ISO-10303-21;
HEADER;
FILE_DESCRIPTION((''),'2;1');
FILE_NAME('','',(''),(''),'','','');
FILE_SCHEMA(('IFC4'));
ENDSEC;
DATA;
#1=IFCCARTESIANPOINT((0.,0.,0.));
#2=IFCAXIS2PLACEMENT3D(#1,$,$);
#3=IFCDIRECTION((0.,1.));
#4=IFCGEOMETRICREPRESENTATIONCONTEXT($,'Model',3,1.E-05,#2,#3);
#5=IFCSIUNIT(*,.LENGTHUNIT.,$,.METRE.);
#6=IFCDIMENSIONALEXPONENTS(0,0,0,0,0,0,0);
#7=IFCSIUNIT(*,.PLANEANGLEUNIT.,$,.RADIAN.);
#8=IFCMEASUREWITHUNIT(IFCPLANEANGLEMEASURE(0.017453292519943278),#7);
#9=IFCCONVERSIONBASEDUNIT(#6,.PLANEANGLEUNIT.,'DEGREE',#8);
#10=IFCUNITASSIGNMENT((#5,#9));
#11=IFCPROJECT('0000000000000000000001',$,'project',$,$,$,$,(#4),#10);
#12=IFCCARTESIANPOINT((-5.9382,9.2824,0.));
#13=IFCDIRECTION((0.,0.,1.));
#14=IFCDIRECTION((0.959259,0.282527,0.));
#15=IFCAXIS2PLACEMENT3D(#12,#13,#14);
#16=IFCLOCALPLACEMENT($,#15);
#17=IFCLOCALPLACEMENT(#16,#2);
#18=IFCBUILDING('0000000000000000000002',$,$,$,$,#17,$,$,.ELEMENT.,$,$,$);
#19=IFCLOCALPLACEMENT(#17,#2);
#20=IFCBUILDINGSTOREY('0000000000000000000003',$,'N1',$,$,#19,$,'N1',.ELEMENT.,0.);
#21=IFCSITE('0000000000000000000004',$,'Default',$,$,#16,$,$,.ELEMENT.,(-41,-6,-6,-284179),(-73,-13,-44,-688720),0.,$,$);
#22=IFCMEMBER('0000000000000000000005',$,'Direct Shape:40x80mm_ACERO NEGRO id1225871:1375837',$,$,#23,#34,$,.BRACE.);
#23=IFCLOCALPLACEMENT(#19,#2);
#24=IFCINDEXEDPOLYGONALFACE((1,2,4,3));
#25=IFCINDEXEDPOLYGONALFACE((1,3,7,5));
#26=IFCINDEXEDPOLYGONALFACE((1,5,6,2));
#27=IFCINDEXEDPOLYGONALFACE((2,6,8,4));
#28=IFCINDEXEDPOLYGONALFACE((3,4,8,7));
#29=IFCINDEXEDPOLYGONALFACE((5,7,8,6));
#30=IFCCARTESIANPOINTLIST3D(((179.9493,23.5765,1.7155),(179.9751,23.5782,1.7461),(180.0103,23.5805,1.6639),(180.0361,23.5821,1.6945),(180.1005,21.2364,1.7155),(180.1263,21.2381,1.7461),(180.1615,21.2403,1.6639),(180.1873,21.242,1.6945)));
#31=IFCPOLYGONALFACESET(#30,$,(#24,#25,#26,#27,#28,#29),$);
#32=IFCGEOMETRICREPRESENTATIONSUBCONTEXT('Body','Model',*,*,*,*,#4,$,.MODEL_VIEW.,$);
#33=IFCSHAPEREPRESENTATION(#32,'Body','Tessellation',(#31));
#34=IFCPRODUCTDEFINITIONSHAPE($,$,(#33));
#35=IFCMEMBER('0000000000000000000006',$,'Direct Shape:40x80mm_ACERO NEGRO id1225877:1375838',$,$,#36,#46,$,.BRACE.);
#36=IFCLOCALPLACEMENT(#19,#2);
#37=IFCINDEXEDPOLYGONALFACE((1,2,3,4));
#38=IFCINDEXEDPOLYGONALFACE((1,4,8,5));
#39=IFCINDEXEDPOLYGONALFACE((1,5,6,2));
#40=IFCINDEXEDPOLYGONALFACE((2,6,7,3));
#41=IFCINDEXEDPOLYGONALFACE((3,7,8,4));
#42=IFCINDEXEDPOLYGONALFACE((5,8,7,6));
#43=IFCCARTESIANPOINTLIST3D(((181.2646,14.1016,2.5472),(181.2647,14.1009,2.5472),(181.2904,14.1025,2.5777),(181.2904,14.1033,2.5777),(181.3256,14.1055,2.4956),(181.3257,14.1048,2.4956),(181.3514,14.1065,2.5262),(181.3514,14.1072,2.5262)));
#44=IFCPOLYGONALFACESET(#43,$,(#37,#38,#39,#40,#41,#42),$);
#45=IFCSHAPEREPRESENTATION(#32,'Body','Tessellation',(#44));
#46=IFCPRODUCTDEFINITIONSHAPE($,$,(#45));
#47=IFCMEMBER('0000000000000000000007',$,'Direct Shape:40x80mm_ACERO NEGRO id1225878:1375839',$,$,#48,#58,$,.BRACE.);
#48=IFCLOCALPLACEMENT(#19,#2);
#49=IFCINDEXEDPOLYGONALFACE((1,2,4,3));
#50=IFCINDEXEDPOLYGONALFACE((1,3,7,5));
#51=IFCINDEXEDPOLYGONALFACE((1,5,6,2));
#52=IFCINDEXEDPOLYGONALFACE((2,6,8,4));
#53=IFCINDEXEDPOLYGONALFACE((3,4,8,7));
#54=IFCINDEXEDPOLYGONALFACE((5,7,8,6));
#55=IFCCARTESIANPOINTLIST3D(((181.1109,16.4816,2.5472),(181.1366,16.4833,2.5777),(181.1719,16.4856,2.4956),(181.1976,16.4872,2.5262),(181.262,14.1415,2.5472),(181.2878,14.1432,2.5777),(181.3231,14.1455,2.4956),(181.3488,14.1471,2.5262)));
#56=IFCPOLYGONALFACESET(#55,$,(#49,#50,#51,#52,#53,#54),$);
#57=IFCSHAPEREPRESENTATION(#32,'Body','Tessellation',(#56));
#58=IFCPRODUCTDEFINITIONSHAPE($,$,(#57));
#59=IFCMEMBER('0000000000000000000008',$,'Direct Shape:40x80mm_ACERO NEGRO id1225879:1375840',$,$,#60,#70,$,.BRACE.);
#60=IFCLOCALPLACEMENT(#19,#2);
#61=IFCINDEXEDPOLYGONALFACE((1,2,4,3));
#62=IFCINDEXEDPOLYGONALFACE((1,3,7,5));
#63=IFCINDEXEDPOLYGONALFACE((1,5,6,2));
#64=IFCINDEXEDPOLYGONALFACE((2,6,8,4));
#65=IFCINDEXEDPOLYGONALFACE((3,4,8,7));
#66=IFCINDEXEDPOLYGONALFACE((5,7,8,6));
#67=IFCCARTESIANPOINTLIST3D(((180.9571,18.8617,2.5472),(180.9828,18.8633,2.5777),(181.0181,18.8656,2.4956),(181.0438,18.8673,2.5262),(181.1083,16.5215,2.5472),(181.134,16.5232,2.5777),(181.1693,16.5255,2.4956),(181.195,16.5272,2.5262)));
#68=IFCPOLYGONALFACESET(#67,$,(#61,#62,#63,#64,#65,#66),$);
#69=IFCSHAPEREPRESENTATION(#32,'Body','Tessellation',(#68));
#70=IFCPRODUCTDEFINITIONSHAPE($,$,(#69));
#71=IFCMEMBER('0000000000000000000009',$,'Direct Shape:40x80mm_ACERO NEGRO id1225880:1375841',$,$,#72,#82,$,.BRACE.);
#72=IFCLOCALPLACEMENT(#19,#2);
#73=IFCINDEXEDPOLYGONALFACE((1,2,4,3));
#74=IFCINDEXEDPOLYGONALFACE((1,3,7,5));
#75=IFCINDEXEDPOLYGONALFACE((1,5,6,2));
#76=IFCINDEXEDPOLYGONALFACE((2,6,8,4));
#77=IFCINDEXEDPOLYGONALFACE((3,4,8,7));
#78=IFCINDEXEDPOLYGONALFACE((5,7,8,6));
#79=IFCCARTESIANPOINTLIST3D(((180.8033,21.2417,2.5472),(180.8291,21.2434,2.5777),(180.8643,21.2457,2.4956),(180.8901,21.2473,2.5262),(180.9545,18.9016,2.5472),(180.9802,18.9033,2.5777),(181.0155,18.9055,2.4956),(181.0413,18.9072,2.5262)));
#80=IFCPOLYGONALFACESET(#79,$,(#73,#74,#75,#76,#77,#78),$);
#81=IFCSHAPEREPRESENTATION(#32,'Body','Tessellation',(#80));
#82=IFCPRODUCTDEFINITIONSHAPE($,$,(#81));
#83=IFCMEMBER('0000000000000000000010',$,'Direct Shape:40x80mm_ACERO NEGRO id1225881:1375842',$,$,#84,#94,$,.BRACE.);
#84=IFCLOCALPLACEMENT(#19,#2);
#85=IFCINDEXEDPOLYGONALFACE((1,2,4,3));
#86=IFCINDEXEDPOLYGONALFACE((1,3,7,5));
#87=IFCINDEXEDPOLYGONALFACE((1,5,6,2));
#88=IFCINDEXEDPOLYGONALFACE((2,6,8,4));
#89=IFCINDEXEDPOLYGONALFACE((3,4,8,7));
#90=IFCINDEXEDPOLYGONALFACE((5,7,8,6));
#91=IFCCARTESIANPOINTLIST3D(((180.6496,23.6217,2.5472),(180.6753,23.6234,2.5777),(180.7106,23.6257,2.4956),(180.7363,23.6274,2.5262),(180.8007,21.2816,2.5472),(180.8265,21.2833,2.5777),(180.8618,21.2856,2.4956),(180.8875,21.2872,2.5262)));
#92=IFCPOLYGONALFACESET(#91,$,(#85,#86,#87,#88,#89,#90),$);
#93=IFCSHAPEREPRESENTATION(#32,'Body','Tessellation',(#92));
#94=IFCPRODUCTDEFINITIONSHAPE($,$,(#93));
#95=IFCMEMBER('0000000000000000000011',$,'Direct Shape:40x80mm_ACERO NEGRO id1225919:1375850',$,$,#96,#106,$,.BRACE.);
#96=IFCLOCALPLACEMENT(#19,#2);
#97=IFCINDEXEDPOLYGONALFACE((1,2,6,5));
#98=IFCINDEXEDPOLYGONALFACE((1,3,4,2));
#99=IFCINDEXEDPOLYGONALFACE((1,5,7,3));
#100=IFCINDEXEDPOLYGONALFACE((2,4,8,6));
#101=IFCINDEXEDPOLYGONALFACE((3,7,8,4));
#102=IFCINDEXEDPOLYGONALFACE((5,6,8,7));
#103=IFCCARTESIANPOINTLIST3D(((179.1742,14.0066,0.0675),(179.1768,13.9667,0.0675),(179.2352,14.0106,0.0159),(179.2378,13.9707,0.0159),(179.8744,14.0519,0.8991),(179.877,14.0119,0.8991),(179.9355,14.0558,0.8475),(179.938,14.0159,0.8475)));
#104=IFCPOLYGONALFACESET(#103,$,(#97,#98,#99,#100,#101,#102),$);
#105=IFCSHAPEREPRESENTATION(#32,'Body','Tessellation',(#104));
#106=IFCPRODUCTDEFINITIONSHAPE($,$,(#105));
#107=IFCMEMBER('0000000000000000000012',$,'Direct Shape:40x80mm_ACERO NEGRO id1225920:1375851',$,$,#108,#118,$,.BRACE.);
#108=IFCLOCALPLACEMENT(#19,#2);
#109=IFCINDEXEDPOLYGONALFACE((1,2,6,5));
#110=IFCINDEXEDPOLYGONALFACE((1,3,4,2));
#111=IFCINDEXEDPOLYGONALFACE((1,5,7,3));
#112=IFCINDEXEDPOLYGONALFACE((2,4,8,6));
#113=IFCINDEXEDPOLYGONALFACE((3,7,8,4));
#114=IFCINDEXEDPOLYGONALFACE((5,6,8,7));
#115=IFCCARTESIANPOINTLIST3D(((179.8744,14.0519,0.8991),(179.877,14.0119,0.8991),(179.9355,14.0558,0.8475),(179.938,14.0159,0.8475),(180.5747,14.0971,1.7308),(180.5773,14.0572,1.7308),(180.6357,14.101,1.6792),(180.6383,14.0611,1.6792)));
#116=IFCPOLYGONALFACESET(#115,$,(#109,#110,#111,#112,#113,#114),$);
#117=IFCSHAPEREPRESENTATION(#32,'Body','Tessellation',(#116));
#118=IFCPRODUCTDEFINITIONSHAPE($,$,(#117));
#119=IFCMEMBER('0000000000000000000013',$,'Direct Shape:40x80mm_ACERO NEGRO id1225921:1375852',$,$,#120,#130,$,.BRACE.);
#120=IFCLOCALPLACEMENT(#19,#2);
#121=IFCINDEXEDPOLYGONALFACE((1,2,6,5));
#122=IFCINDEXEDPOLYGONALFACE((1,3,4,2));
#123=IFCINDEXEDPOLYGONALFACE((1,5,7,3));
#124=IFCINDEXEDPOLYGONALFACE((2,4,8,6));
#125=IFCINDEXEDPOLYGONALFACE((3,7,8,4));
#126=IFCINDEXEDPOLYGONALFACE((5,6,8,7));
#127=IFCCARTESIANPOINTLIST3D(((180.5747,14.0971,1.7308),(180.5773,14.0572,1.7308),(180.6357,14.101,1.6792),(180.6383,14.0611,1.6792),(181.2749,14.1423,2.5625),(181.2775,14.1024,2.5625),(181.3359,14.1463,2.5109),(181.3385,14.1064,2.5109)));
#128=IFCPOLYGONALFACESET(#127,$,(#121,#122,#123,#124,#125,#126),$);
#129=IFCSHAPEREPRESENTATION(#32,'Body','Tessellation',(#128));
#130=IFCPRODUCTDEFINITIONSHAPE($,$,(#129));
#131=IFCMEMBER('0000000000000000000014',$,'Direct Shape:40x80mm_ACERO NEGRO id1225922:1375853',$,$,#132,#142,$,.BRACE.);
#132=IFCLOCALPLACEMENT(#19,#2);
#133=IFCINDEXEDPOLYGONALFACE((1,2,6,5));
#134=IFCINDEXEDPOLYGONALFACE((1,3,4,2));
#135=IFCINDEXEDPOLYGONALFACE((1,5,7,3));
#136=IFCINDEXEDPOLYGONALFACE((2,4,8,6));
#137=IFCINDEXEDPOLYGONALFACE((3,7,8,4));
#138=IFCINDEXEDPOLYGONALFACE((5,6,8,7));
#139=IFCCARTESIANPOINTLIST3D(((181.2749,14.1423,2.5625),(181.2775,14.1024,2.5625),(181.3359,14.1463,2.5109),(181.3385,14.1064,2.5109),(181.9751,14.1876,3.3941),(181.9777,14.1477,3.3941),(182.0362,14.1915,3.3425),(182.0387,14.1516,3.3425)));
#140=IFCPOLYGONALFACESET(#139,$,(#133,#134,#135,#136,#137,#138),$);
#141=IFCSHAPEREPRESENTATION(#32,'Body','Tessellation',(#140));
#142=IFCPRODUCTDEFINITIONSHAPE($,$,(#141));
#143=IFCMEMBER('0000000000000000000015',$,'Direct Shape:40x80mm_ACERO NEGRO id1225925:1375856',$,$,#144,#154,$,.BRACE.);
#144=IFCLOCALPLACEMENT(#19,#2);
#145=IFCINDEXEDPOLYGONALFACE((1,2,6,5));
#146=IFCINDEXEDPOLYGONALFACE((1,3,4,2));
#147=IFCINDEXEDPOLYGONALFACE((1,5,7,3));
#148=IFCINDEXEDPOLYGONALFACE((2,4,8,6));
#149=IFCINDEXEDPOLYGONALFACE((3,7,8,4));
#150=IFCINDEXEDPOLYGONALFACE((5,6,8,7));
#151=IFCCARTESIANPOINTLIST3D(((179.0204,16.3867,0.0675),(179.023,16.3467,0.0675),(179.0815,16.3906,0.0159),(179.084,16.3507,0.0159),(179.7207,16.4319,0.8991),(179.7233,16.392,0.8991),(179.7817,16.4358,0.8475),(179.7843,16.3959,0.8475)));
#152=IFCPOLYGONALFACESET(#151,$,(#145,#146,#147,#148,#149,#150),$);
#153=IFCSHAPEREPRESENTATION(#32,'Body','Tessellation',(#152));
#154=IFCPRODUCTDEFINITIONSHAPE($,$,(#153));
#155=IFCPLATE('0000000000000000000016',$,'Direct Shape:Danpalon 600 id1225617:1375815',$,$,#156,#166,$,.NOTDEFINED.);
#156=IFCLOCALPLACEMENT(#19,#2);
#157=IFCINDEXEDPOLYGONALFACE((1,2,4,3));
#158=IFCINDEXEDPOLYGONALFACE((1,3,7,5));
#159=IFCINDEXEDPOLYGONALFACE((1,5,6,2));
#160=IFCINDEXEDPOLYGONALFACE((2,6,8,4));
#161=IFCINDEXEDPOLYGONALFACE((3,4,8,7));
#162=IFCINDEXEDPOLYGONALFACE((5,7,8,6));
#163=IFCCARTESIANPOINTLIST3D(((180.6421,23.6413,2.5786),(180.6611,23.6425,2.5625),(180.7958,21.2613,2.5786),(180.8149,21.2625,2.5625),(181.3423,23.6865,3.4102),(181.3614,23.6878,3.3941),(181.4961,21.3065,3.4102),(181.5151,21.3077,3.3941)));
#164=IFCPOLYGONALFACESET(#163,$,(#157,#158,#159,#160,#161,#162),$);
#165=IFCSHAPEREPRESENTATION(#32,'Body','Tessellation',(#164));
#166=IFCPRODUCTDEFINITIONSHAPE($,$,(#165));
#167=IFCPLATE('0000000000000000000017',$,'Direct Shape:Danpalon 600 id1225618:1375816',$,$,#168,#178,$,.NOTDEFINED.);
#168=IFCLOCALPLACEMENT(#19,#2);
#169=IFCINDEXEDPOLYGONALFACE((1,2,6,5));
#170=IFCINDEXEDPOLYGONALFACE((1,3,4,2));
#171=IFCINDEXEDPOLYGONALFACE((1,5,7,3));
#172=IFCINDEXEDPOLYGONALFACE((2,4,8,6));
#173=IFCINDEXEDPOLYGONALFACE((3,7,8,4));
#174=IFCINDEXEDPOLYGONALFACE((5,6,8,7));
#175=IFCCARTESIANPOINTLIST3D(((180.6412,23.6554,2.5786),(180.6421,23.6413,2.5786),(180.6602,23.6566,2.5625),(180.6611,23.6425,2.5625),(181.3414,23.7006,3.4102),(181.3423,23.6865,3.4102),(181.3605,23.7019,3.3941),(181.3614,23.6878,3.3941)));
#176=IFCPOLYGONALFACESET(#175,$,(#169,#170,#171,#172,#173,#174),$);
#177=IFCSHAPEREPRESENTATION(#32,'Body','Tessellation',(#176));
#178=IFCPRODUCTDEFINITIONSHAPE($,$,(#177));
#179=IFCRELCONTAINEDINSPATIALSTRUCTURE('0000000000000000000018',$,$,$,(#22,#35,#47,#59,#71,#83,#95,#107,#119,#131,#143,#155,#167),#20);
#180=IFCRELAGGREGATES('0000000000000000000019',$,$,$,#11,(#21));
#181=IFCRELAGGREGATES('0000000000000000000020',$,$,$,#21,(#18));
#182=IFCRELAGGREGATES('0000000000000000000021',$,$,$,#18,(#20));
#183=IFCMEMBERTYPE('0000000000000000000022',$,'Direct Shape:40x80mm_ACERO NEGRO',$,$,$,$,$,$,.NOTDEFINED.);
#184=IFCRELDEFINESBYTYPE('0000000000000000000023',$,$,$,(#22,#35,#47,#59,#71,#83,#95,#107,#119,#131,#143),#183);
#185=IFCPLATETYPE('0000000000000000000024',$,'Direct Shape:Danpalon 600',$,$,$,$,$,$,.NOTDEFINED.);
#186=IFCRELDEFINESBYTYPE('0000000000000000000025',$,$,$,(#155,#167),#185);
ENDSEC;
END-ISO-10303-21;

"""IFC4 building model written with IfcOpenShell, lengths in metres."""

from ifc_helpers import new_model, entity, si_unit, converted_unit, direction, frame, frame_2d, origin, place, context, subcontext, project, spatial, rectangle, extrude, type_object, element, save


model = new_model("IFC4")

# Units and contexts
model_context = context("Model", 3, precision=1e-05, world=origin(), true_north=direction((0.0, 1.0)))
body_context = subcontext(model_context, "Body", "Model", "MODEL_VIEW")
ifc_project = project(units=[si_unit("LENGTHUNIT", "METRE"), converted_unit("PLANEANGLEUNIT", "DEGREE", entity("IfcPlaneAngleMeasure", 0.017453292519943278), si_unit("PLANEANGLEUNIT", "RADIAN"), dimensions=[0, 0, 0, 0, 0, 0, 0])], contexts=[model_context])

# Site, building, storey
site_placement = place(None, frame((-5.9382, 9.2824, 0.0), z_axis=(0.0, 0.0, 1.0), x_axis=(0.959259, 0.282527, 0.0)))
site = spatial("IfcSite", under=ifc_project, at=site_placement, Name="Default", CompositionType="ELEMENT", RefLatitude=(-41, -6, -6, -284179), RefLongitude=(-73, -13, -44, -688720), RefElevation=0.0)
building_placement = place(site_placement, origin())
building = spatial("IfcBuilding", under=site, at=building_placement, CompositionType="ELEMENT")
storey_placement = place(building_placement, origin())
storey = spatial("IfcBuildingStorey", under=building, at=storey_placement, Name="N1", LongName="N1", CompositionType="ELEMENT", Elevation=0.0)

# Members
member_type = type_object("IfcMemberType", Name="Direct Shape:40x80mm_ACERO NEGRO", PredefinedType="NOTDEFINED")
member_1_placement = place(storey_placement, origin())
element("IfcMember", 1, at=member_1_placement, inside=storey, type_object=member_type, Name="Direct Shape:40x80mm_ACERO NEGRO id1225871:1375837", PredefinedType="BRACE", context=body_context, shape_type="SweptSolid", body=[
    extrude(rectangle(XDim=0.04, YDim=0.08, at=frame_2d((0.0, 0.0), x_axis=(0.0, 1.0))), frame((180.1439, 21.2392, 1.705), z_axis=(-0.064471, 0.99792, 0.0), x_axis=(0.762714, 0.049276, -0.644857)), (0.0, 0.0, 1.0), 2.345),
])
member_2_placement = place(storey_placement, origin())
element("IfcMember", 2, at=member_2_placement, inside=storey, type_object=member_type, Name="Direct Shape:40x80mm_ACERO NEGRO id1225877:1375838", PredefinedType="BRACE", context=body_context, shape_type="SweptSolid", body=[
    extrude(rectangle(XDim=0.04, YDim=0.0007, at=frame_2d((0.0, 0.0), x_axis=(0.0, 1.0))), frame((181.2775, 14.1021, 2.5625), z_axis=(0.762714, 0.049276, -0.644857), x_axis=(-0.064471, 0.99792, 0.0)), (0.0, 0.0, 1.0), 0.08),
])
member_3_placement = place(storey_placement, origin())
element("IfcMember", 3, at=member_3_placement, inside=storey, type_object=member_type, Name="Direct Shape:40x80mm_ACERO NEGRO id1225878:1375839", PredefinedType="BRACE", context=body_context, shape_type="SweptSolid", body=[
    extrude(rectangle(XDim=0.04, YDim=0.08, at=frame_2d((0.0, 0.0), x_axis=(0.0, 1.0))), frame((181.3054, 14.1443, 2.5367), z_axis=(-0.064471, 0.99792, 0.0), x_axis=(0.762714, 0.049276, -0.644857)), (0.0, 0.0, 1.0), 2.345),
])
member_4_placement = place(storey_placement, origin())
element("IfcMember", 4, at=member_4_placement, inside=storey, type_object=member_type, Name="Direct Shape:40x80mm_ACERO NEGRO id1225879:1375840", PredefinedType="BRACE", context=body_context, shape_type="SweptSolid", body=[
    extrude(rectangle(XDim=0.04, YDim=0.08, at=frame_2d((0.0, 0.0), x_axis=(0.0, 1.0))), frame((181.1517, 16.5244, 2.5367), z_axis=(-0.064471, 0.99792, 0.0), x_axis=(0.762714, 0.049276, -0.644857)), (0.0, 0.0, 1.0), 2.345),
])
member_5_placement = place(storey_placement, origin())
element("IfcMember", 5, at=member_5_placement, inside=storey, type_object=member_type, Name="Direct Shape:40x80mm_ACERO NEGRO id1225880:1375841", PredefinedType="BRACE", context=body_context, shape_type="SweptSolid", body=[
    extrude(rectangle(XDim=0.04, YDim=0.08, at=frame_2d((0.0, 0.0), x_axis=(0.0, 1.0))), frame((180.9979, 18.9044, 2.5367), z_axis=(-0.064471, 0.99792, 0.0), x_axis=(0.762714, 0.049276, -0.644857)), (0.0, 0.0, 1.0), 2.345),
])
member_6_placement = place(storey_placement, origin())
element("IfcMember", 6, at=member_6_placement, inside=storey, type_object=member_type, Name="Direct Shape:40x80mm_ACERO NEGRO id1225881:1375842", PredefinedType="BRACE", context=body_context, shape_type="SweptSolid", body=[
    extrude(rectangle(XDim=0.04, YDim=0.08, at=frame_2d((0.0, 0.0), x_axis=(0.0, 1.0))), frame((180.8441, 21.2844, 2.5367), z_axis=(-0.064471, 0.99792, 0.0), x_axis=(0.762714, 0.049276, -0.644857)), (0.0, 0.0, 1.0), 2.345),
])
member_7_placement = place(storey_placement, origin())
element("IfcMember", 7, at=member_7_placement, inside=storey, type_object=member_type, Name="Direct Shape:40x80mm_ACERO NEGRO id1225919:1375850", PredefinedType="BRACE", context=body_context, shape_type="SweptSolid", body=[
    extrude(rectangle(XDim=0.08, YDim=0.04, at=frame_2d((0.0, 0.0), x_axis=(0.0, 1.0))), frame((179.206, 13.9886, 0.0417), z_axis=(0.643515, 0.041575, 0.764304), x_axis=(0.064471, -0.99792, 0.0)), (0.0, 0.0, 1.0), 1.0881),
])
member_8_placement = place(storey_placement, origin())
element("IfcMember", 8, at=member_8_placement, inside=storey, type_object=member_type, Name="Direct Shape:40x80mm_ACERO NEGRO id1225920:1375851", PredefinedType="BRACE", context=body_context, shape_type="SweptSolid", body=[
    extrude(rectangle(XDim=0.08, YDim=0.04, at=frame_2d((0.0, 0.0), x_axis=(0.0, 1.0))), frame((179.9062, 14.0339, 0.8733), z_axis=(0.643515, 0.041575, 0.764304), x_axis=(0.064471, -0.99792, 0.0)), (0.0, 0.0, 1.0), 1.0881),
])
member_9_placement = place(storey_placement, origin())
element("IfcMember", 9, at=member_9_placement, inside=storey, type_object=member_type, Name="Direct Shape:40x80mm_ACERO NEGRO id1225921:1375852", PredefinedType="BRACE", context=body_context, shape_type="SweptSolid", body=[
    extrude(rectangle(XDim=0.08, YDim=0.04, at=frame_2d((0.0, 0.0), x_axis=(0.0, 1.0))), frame((180.6065, 14.0791, 1.705), z_axis=(0.643515, 0.041575, 0.764304), x_axis=(0.064471, -0.99792, 0.0)), (0.0, 0.0, 1.0), 1.0881),
])
member_10_placement = place(storey_placement, origin())
element("IfcMember", 10, at=member_10_placement, inside=storey, type_object=member_type, Name="Direct Shape:40x80mm_ACERO NEGRO id1225922:1375853", PredefinedType="BRACE", context=body_context, shape_type="SweptSolid", body=[
    extrude(rectangle(XDim=0.08, YDim=0.04, at=frame_2d((0.0, 0.0), x_axis=(0.0, 1.0))), frame((181.3067, 14.1244, 2.5367), z_axis=(0.643515, 0.041575, 0.764304), x_axis=(0.064471, -0.99792, 0.0)), (0.0, 0.0, 1.0), 1.0881),
])
member_11_placement = place(storey_placement, origin())
element("IfcMember", 11, at=member_11_placement, inside=storey, type_object=member_type, Name="Direct Shape:40x80mm_ACERO NEGRO id1225925:1375856", PredefinedType="BRACE", context=body_context, shape_type="SweptSolid", body=[
    extrude(rectangle(XDim=0.08, YDim=0.04, at=frame_2d((0.0, 0.0), x_axis=(0.0, 1.0))), frame((179.0522, 16.3687, 0.0417), z_axis=(0.643515, 0.041575, 0.764304), x_axis=(0.064471, -0.99792, 0.0)), (0.0, 0.0, 1.0), 1.0881),
])

# Plates
plate_type = type_object("IfcPlateType", Name="Direct Shape:Danpalon 600", PredefinedType="NOTDEFINED")
plate_1_placement = place(storey_placement, origin())
element("IfcPlate", 12, at=plate_1_placement, inside=storey, type_object=plate_type, Name="Direct Shape:Danpalon 600 id1225617:1375815", PredefinedType="NOTDEFINED", context=body_context, shape_type="SweptSolid", body=[
    extrude(rectangle(XDim=1.0881, YDim=0.025, at=frame_2d((0.0, 0.0), x_axis=(0.0, 1.0))), frame((181.1555, 21.2845, 2.9864), z_axis=(-0.064471, 0.99792, 0.0), x_axis=(-0.762714, -0.049276, 0.644857)), (0.0, 0.0, 1.0), 2.385),
])
plate_2_placement = place(storey_placement, origin())
element("IfcPlate", 13, at=plate_2_placement, inside=storey, type_object=plate_type, Name="Direct Shape:Danpalon 600 id1225618:1375816", PredefinedType="NOTDEFINED", context=body_context, shape_type="SweptSolid", body=[
    extrude(rectangle(XDim=0.025, YDim=0.0141, at=frame_2d((0.0, 0.0), x_axis=(0.0, 1.0))), frame((180.6512, 23.649, 2.5705), z_axis=(0.643515, 0.041575, 0.764304), x_axis=(0.064471, -0.99792, 0.0)), (0.0, 0.0, 1.0), 1.0881),
])

save(model, "model.ifc")
